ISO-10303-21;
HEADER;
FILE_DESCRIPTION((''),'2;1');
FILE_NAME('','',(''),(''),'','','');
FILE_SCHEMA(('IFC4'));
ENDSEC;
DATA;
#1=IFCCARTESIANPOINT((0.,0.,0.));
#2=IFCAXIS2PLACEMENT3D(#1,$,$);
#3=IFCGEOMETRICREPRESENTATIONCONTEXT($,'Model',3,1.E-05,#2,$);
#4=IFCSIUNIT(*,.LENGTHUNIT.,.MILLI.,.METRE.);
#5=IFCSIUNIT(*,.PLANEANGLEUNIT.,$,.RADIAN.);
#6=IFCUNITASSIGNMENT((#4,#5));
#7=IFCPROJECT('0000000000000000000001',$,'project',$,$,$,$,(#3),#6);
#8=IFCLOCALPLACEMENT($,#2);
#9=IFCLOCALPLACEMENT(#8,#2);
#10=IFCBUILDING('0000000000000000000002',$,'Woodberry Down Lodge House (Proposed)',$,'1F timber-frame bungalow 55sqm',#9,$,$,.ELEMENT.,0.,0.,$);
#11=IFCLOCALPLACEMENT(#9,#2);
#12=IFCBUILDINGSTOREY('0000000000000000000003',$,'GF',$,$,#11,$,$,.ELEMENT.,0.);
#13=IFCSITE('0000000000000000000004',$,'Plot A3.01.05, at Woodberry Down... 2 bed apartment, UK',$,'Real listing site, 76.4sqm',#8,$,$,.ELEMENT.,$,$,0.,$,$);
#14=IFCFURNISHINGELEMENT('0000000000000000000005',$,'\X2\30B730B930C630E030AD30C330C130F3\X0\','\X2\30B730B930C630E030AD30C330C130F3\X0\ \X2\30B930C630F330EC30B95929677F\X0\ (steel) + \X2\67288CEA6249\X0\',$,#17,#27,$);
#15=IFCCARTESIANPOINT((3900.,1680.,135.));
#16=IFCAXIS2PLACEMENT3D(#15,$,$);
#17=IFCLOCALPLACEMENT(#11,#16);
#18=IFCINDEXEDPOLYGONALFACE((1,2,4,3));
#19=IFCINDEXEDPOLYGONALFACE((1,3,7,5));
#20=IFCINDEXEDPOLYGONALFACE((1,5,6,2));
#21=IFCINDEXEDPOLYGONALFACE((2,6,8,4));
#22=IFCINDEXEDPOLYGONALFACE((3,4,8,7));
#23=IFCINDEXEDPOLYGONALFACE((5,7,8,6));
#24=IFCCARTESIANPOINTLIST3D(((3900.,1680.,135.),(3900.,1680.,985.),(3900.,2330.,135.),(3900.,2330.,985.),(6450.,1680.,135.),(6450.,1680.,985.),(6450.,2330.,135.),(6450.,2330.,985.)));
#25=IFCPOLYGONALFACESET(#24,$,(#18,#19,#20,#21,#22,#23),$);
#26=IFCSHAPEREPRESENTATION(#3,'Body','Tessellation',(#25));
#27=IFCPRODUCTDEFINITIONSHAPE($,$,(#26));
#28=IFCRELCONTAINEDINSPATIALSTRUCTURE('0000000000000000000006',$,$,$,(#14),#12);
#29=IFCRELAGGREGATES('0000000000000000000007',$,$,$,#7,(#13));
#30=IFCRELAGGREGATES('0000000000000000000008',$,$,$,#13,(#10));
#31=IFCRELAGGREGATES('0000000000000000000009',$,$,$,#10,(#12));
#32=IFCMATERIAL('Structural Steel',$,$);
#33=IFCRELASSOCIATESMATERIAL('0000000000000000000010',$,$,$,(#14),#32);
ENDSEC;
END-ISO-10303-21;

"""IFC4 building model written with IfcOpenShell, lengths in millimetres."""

from ifc_helpers import new_model, si_unit, frame, frame_2d, origin, place, context, project, spatial, rectangle, extrude, material, element, save


model = new_model("IFC4")

# Units and contexts
model_context = context("Model", 3, precision=1e-05, world=origin())
ifc_project = project(units=[si_unit("LENGTHUNIT", "METRE", prefix="MILLI"), si_unit("PLANEANGLEUNIT", "RADIAN")], contexts=[model_context])

# Site, building, storey
site_placement = place(None, origin())
site = spatial("IfcSite", under=ifc_project, at=site_placement, Name="Plot A3.01.05, at Woodberry Down... 2 bed apartment, UK", ObjectType="Real listing site, 76.4sqm", CompositionType="ELEMENT", RefElevation=0.0)
building_placement = place(site_placement, origin())
building = spatial("IfcBuilding", under=site, at=building_placement, Name="Woodberry Down Lodge House (Proposed)", ObjectType="1F timber-frame bungalow 55sqm", CompositionType="ELEMENT", ElevationOfRefHeight=0.0, ElevationOfTerrain=0.0)
storey_placement = place(building_placement, origin())
storey = spatial("IfcBuildingStorey", under=building, at=storey_placement, Name="GF", CompositionType="ELEMENT", Elevation=0.0)

# Furnishing element
ifc_material_1 = material(Name="Structural Steel")
furnishing_placement = place(storey_placement, frame((3900.0, 1680.0, 135.0)))
element("IfcFurnishingElement", 1, at=furnishing_placement, inside=storey, material=ifc_material_1, Name="システムキッチン", Description="システムキッチン ステンレス天板 (steel) + 木質扉", context=model_context, shape_type="SweptSolid", body=[
    extrude(rectangle(XDim=2550.0, YDim=650.0, at=frame_2d((1275.0, 325.0))), frame((3900.0, 1680.0, 135.0)), (0.0, 0.0, 1.0), 850.0),
])

save(model, "model.ifc")
